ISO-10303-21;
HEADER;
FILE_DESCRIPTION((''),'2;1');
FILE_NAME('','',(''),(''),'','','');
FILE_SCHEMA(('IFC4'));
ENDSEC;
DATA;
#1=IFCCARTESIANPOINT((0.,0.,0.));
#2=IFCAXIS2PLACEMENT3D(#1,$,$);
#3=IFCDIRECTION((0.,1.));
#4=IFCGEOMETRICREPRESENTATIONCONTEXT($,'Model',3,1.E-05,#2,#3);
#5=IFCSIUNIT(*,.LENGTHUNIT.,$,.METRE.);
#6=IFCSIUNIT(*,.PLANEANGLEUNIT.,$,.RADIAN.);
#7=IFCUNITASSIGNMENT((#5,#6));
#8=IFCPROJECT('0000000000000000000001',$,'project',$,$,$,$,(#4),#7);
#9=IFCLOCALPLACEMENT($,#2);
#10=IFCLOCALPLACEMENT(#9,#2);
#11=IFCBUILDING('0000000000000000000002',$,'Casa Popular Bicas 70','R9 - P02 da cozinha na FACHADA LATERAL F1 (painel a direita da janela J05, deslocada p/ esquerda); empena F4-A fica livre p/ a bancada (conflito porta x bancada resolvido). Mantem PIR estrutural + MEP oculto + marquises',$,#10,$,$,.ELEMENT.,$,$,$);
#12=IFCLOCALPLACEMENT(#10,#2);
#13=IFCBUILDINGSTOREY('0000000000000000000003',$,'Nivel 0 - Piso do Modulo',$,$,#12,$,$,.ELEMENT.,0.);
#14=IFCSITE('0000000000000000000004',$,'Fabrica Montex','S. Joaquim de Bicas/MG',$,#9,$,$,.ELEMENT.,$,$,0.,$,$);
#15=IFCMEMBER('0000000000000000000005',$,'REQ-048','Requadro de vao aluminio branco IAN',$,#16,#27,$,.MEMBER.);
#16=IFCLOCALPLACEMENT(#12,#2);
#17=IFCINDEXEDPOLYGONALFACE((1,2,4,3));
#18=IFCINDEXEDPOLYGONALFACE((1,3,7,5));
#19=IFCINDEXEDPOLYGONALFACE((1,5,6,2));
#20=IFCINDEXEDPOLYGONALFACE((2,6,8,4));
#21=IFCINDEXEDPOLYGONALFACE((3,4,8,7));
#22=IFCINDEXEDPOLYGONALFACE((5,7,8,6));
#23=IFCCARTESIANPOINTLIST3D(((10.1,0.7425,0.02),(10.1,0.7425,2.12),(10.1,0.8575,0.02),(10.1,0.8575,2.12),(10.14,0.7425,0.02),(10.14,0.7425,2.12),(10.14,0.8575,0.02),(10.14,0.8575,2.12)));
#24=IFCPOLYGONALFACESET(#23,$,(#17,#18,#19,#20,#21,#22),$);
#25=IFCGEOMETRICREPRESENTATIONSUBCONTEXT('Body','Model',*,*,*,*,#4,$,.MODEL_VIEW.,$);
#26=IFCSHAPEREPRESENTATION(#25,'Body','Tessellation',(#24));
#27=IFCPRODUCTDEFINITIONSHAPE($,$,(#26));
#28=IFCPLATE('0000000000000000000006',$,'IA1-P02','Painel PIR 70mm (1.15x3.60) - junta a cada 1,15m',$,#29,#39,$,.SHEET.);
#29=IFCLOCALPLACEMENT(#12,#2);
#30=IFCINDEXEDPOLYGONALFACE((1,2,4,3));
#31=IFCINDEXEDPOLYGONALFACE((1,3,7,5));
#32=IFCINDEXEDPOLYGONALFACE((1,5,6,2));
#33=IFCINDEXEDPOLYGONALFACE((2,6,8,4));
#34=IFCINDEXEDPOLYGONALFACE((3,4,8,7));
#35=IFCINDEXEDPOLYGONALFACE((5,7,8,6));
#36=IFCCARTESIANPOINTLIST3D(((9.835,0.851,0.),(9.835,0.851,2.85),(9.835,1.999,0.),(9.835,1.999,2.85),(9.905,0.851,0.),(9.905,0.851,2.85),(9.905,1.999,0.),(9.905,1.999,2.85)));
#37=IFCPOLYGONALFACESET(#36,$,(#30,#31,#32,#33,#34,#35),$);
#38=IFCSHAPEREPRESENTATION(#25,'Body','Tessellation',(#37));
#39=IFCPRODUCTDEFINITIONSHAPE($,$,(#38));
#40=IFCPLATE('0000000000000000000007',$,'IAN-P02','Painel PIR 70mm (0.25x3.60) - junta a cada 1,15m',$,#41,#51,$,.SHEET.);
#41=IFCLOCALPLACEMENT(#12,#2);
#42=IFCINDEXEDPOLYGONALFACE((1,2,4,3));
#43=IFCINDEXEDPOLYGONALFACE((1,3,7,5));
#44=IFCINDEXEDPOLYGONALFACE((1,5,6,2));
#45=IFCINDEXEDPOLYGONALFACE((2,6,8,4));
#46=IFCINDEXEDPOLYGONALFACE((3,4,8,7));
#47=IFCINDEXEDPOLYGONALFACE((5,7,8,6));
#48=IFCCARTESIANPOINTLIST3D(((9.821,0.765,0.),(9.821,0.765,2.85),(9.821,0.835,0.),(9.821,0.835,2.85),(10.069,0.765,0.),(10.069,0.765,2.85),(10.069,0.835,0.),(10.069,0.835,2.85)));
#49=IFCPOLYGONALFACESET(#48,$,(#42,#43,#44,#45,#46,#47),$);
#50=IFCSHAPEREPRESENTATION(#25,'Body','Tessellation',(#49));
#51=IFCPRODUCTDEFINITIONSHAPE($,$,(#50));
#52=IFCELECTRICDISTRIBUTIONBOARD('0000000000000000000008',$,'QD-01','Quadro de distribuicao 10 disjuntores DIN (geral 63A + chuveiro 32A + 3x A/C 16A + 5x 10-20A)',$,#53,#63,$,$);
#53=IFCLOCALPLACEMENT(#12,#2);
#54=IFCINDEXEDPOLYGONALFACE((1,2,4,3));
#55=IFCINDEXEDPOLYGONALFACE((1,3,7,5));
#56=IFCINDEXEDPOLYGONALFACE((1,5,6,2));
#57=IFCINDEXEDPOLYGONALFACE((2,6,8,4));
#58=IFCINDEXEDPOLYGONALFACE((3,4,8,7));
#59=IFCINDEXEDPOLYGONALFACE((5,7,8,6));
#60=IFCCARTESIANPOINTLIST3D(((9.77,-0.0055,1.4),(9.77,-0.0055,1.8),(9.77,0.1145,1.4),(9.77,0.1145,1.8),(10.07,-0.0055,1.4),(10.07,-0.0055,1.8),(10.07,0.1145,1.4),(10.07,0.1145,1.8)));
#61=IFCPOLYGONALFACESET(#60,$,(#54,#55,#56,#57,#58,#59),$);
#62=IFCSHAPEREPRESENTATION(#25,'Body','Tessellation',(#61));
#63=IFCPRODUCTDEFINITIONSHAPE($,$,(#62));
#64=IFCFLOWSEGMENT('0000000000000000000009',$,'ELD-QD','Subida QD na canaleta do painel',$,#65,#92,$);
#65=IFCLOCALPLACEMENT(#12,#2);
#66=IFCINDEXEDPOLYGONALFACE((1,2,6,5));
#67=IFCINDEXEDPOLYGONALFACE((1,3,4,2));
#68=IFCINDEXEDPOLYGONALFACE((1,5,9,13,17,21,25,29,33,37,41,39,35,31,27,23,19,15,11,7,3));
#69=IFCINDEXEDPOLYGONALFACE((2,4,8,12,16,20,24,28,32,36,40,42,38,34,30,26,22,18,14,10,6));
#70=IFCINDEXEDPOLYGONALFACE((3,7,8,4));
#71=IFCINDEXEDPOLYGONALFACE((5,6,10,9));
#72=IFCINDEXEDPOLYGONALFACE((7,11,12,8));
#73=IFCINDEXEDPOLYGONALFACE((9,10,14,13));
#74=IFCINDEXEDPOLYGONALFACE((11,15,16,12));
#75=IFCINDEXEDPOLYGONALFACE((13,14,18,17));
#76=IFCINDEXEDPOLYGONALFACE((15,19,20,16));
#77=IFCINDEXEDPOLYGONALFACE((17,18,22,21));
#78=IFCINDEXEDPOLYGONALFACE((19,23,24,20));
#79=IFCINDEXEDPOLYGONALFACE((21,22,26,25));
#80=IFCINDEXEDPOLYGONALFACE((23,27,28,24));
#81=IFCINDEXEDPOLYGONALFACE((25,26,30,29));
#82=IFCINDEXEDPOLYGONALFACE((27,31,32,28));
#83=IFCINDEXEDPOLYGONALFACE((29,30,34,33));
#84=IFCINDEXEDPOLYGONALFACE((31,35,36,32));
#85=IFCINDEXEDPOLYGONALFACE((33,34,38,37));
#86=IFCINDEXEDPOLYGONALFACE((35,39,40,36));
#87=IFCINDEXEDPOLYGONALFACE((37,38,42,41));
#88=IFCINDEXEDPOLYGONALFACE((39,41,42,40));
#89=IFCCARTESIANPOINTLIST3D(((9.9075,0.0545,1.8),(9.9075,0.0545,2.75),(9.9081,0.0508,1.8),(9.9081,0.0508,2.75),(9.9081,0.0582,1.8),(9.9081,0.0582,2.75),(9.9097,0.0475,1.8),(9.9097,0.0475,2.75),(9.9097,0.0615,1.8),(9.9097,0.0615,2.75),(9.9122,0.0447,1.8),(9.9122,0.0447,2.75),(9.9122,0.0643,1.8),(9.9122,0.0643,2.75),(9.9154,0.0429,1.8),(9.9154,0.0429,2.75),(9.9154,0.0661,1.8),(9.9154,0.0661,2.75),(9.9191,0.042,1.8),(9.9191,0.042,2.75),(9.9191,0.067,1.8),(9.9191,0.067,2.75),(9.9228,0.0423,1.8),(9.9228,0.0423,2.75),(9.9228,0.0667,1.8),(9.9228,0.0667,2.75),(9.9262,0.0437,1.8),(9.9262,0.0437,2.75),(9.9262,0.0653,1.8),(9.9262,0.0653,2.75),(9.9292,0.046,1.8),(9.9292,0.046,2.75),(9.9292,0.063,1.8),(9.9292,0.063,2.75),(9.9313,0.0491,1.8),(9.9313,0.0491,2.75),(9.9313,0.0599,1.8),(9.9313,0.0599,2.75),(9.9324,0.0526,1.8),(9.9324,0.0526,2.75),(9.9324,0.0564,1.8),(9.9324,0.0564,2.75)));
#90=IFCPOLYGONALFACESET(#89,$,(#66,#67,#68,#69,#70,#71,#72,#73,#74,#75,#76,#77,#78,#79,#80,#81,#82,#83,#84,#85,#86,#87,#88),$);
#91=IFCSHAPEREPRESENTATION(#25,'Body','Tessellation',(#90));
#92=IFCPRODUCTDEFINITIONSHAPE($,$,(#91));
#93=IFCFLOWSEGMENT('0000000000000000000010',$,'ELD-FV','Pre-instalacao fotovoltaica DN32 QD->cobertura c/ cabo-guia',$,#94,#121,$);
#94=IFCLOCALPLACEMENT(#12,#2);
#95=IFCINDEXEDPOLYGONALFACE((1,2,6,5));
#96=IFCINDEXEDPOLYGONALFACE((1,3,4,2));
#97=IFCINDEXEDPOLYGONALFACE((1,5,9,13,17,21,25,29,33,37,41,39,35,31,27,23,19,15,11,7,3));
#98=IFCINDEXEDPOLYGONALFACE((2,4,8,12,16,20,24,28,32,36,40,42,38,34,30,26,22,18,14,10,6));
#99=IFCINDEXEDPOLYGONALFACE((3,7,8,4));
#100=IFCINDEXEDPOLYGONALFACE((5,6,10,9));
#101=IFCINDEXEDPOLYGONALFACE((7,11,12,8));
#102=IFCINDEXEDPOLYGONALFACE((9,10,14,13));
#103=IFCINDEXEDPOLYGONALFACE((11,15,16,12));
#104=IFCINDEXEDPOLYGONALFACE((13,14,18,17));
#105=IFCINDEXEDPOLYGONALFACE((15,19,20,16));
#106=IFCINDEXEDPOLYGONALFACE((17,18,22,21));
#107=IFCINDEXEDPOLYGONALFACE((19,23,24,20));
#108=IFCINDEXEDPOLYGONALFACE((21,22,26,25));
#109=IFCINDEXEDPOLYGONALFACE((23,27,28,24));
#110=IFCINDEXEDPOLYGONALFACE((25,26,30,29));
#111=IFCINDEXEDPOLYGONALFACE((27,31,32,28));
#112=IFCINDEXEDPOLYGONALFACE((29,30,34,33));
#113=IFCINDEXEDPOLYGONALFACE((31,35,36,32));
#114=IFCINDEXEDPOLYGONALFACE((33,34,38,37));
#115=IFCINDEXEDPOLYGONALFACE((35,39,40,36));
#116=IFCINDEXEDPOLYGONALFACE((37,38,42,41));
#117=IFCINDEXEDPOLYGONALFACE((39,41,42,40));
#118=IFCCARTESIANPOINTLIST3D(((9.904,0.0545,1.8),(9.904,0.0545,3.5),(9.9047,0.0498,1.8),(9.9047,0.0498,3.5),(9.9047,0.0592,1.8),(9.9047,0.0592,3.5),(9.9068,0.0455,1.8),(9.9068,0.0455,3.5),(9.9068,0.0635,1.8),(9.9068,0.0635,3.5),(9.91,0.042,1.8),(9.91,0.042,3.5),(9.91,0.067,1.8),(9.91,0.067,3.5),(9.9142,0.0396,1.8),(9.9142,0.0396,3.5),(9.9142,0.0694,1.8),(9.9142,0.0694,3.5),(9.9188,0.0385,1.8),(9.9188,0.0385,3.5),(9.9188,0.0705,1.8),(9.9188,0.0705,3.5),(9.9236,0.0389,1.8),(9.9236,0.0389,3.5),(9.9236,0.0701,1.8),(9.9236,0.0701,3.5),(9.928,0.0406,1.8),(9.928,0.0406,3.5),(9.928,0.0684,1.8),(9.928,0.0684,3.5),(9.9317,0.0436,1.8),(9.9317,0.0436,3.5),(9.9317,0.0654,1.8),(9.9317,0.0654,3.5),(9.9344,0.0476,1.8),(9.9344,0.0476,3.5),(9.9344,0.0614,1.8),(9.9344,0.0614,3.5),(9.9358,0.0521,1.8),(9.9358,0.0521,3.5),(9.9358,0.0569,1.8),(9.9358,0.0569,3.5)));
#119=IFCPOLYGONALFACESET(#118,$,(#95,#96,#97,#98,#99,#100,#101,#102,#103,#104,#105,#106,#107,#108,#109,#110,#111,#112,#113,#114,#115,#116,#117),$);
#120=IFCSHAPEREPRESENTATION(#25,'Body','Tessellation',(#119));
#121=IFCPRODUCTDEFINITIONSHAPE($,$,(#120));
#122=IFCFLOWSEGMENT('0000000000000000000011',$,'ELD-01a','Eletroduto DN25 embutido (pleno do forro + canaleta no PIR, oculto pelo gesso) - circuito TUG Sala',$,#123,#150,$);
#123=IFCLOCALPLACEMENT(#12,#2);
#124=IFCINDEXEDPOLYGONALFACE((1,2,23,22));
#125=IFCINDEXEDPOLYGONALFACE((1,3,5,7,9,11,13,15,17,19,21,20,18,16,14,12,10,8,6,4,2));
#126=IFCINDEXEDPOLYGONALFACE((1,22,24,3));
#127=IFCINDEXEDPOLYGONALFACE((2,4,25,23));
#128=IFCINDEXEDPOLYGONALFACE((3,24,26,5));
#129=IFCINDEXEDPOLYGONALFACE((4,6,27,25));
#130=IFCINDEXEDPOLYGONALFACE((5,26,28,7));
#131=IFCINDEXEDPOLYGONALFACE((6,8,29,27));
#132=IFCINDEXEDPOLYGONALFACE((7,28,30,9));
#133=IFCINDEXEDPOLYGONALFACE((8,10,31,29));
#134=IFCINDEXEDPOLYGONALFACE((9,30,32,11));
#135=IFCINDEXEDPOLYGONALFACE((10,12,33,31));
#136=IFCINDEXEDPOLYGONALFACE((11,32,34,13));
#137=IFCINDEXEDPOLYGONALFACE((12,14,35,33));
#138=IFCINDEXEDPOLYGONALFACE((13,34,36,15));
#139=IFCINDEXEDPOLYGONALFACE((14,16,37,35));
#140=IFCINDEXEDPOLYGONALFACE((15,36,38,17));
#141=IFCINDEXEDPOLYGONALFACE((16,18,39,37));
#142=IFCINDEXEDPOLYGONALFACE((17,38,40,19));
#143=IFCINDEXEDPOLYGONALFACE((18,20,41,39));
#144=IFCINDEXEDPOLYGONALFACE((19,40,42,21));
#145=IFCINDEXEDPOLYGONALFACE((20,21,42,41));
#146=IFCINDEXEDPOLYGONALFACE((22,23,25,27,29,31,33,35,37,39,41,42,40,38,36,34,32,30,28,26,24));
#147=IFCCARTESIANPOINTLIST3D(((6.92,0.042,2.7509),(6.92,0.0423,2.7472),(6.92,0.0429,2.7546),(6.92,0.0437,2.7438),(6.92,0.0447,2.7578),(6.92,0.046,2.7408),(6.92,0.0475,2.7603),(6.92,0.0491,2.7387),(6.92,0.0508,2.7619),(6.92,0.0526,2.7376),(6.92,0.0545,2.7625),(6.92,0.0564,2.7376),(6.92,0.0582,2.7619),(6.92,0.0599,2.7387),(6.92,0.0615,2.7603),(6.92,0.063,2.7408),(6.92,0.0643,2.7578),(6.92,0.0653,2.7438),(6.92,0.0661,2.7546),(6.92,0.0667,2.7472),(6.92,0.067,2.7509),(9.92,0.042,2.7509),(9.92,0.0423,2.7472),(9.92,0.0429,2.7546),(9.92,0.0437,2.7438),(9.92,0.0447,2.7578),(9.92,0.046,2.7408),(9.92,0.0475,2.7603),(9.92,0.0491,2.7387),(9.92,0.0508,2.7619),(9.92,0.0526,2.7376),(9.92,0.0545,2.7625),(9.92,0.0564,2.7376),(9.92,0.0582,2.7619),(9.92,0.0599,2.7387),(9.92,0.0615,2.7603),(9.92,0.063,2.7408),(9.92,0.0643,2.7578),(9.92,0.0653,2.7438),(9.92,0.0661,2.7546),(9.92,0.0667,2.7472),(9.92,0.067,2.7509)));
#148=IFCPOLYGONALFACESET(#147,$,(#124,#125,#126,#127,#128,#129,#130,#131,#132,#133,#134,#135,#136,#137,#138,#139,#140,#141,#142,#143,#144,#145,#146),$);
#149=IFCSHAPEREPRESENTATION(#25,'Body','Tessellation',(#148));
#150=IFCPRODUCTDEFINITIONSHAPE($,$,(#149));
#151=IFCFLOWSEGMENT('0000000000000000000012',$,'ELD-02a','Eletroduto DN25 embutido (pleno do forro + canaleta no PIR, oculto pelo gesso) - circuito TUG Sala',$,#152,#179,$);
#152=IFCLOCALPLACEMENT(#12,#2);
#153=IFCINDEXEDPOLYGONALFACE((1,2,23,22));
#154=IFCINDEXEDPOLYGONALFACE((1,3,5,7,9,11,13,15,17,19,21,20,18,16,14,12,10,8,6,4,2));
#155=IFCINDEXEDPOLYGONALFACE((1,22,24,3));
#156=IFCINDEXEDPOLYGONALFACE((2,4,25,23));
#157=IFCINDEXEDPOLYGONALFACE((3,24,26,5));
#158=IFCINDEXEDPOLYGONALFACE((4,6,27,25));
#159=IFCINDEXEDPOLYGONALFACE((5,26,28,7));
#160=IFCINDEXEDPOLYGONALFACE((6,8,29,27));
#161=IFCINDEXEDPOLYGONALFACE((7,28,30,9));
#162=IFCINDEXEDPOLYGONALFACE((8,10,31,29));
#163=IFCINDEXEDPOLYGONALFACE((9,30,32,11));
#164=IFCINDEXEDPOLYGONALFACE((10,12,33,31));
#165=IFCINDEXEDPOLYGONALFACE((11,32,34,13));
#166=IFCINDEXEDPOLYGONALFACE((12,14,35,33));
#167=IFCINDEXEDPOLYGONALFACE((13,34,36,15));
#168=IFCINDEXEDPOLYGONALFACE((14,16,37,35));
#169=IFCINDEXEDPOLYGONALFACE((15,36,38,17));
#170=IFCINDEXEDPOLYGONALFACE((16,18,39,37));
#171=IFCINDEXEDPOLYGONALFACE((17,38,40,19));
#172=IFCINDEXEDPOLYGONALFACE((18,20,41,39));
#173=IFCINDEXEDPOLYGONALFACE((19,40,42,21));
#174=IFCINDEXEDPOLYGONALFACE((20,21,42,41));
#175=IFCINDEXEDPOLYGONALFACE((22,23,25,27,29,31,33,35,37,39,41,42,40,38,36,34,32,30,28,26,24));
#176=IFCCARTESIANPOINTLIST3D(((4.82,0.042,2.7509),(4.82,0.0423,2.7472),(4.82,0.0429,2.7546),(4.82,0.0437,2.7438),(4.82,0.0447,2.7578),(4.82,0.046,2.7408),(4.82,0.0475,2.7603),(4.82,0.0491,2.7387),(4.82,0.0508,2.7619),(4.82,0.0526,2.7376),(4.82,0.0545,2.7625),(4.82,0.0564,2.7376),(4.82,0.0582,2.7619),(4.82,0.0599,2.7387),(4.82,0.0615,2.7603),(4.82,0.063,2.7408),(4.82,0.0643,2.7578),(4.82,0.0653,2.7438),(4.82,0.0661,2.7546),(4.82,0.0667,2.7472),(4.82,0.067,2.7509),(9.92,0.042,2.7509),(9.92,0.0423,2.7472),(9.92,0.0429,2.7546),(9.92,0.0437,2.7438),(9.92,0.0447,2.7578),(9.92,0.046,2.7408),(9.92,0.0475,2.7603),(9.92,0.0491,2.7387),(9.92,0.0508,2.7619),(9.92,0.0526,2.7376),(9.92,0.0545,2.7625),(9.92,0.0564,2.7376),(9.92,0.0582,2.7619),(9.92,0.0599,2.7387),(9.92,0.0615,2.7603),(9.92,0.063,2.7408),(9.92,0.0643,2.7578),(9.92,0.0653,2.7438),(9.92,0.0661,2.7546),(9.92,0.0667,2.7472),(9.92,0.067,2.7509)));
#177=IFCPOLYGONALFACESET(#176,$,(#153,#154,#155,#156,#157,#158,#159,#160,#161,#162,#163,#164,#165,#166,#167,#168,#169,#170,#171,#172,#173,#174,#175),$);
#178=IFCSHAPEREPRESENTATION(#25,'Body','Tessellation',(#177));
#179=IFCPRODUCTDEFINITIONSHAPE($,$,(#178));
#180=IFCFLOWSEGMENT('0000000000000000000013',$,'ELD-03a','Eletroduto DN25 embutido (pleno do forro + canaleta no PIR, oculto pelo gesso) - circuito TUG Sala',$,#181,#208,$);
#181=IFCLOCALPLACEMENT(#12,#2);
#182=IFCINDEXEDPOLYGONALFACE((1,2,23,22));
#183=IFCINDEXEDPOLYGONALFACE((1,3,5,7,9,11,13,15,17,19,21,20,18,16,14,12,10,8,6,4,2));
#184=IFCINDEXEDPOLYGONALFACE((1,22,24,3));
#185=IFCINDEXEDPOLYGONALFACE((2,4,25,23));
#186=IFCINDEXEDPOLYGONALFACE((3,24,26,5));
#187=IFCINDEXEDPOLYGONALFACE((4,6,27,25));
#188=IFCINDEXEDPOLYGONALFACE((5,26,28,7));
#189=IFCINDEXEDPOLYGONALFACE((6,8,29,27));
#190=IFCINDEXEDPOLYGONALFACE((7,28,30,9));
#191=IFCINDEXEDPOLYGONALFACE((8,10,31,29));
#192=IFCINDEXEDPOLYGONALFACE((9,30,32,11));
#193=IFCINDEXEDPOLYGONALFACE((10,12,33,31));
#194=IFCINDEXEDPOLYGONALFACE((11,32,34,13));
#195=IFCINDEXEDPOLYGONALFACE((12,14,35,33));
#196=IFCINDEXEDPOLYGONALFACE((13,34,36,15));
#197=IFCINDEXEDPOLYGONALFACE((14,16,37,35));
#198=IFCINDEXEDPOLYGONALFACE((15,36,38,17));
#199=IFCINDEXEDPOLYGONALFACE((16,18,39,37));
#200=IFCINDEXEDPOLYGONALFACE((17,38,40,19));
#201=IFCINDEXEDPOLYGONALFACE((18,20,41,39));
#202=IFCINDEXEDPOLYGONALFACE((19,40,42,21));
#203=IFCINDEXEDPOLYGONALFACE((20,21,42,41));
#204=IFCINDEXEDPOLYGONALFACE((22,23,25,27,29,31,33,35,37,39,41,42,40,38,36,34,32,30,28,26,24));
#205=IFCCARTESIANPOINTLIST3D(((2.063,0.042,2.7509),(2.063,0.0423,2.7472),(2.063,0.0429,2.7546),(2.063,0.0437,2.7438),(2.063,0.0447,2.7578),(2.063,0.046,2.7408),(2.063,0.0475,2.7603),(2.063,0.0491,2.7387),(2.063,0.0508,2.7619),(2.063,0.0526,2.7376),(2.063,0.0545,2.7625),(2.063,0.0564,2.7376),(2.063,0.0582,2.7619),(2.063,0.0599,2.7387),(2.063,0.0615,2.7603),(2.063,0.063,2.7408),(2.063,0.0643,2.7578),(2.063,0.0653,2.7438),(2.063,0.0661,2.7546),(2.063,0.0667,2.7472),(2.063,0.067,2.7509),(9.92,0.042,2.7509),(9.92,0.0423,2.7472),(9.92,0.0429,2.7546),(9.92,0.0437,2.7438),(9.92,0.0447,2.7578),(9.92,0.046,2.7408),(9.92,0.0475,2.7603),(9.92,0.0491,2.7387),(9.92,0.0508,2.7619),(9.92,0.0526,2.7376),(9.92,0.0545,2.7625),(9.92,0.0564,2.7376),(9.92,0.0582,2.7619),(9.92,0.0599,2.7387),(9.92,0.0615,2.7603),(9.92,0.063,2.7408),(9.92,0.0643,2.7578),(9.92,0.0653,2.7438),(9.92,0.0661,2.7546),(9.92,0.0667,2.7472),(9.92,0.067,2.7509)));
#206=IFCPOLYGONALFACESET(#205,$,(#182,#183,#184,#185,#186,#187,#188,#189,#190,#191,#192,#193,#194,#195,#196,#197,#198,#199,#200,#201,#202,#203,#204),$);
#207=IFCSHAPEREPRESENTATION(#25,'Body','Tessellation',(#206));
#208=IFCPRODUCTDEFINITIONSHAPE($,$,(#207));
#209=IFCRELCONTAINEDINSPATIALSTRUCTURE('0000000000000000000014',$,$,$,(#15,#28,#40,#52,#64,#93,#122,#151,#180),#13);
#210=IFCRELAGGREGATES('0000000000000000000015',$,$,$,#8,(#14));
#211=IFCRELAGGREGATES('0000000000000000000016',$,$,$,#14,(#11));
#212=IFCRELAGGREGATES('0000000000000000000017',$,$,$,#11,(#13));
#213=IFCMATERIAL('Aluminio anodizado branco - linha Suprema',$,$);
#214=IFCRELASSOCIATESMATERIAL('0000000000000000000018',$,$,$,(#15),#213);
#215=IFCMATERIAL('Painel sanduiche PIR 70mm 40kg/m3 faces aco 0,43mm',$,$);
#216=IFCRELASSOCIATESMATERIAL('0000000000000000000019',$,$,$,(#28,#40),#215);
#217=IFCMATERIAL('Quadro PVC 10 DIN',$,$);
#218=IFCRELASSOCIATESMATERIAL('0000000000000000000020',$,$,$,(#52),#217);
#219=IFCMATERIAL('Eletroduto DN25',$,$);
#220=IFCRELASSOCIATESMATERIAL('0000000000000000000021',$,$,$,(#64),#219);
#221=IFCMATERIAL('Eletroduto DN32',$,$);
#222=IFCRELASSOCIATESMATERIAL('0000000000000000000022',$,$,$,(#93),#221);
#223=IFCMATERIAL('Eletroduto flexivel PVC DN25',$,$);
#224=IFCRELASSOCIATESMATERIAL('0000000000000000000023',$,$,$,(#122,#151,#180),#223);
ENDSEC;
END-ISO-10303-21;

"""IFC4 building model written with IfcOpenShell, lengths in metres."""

from ifc_helpers import new_model, si_unit, direction, frame, frame_2d, origin, origin_2d, place, context, subcontext, project, spatial, rectangle, circle, extrude, material, element, save


model = new_model("IFC4")

# Units and contexts
model_context = context("Model", 3, precision=1e-05, world=origin(), true_north=direction((0.0, 1.0)))
body_context = subcontext(model_context, "Body", "Model", "MODEL_VIEW")
ifc_project = project(units=[si_unit("LENGTHUNIT", "METRE"), si_unit("PLANEANGLEUNIT", "RADIAN")], contexts=[model_context])

# Site, building, storey
site_placement = place(None, origin())
site = spatial("IfcSite", under=ifc_project, at=site_placement, Name="Fabrica Montex", Description="S. Joaquim de Bicas/MG", CompositionType="ELEMENT", RefElevation=0.0)
building_placement = place(site_placement, origin())
building = spatial("IfcBuilding", under=site, at=building_placement, Name="Casa Popular Bicas 70", Description="R9 - P02 da cozinha na FACHADA LATERAL F1 (painel a direita da janela J05, deslocada p/ esquerda); empena F4-A fica livre p/ a bancada (conflito porta x bancada resolvido). Mantem PIR estrutural + MEP oculto + marquises", CompositionType="ELEMENT")
storey_placement = place(building_placement, origin())
storey = spatial("IfcBuildingStorey", under=building, at=storey_placement, Name="Nivel 0 - Piso do Modulo", CompositionType="ELEMENT", Elevation=0.0)

# Member
ifc_material_1 = material(Name="Aluminio anodizado branco - linha Suprema")
member_placement = place(None, frame((10.12, 0.8, 0.02), z_axis=(0.0, 0.0, 1.0), x_axis=(-1.0, 0.0, 0.0)))
element("IfcMember", 1, at=member_placement, inside=storey, material=ifc_material_1, Name="REQ-048", Description="Requadro de vao aluminio branco IAN", PredefinedType="MEMBER", context=body_context, shape_type="SweptSolid", body=[
    extrude(rectangle(XDim=0.04, YDim=0.115, at=origin_2d()), origin(), (0.0, 0.0, 1.0), 2.1),
])

# Shared definitions
ifc_material_2 = material(Name="Painel sanduiche PIR 70mm 40kg/m3 faces aco 0,43mm")

# Plates
plate_1_placement = place(None, frame((9.87, 1.999, 0.0), z_axis=(0.0, 0.0, 1.0), x_axis=(0.0, -1.0, 0.0)))
element("IfcPlate", 2, at=plate_1_placement, inside=storey, material=ifc_material_2, Name="IA1-P02", Description="Painel PIR 70mm (1.15x3.60) - junta a cada 1,15m", PredefinedType="SHEET", context=body_context, shape_type="SweptSolid", body=[
    extrude(rectangle(XDim=1.148, YDim=0.07, at=frame_2d((0.574, 0.0))), origin(), (0.0, 0.0, 1.0), 2.85),
])
plate_2_placement = place(None, frame((10.069, 0.8, 0.0), z_axis=(0.0, 0.0, 1.0), x_axis=(-1.0, 0.0, 0.0)))
element("IfcPlate", 3, at=plate_2_placement, inside=storey, material=ifc_material_2, Name="IAN-P02", Description="Painel PIR 70mm (0.25x3.60) - junta a cada 1,15m", PredefinedType="SHEET", context=body_context, shape_type="SweptSolid", body=[
    extrude(rectangle(XDim=0.248, YDim=0.07, at=frame_2d((0.124, 0.0))), origin(), (0.0, 0.0, 1.0), 2.85),
])

# Electric distribution board
ifc_material_3 = material(Name="Quadro PVC 10 DIN")
electric_distribution_board_placement = place(None, frame((10.07, 0.1145, 1.4), z_axis=(0.0, 0.0, 1.0), x_axis=(-1.0, 0.0, 0.0)))
element("IfcElectricDistributionBoard", 4, at=electric_distribution_board_placement, inside=storey, material=ifc_material_3, Name="QD-01", Description="Quadro de distribuicao 10 disjuntores DIN (geral 63A + chuveiro 32A + 3x A/C 16A + 5x 10-20A)", context=body_context, shape_type="SweptSolid", body=[
    extrude(rectangle(XDim=0.3, YDim=0.12, at=frame_2d((0.15, 0.06))), origin(), (0.0, 0.0, 1.0), 0.4),
])

# Flow segments
ifc_material_4 = material(Name="Eletroduto DN25")
flow_segment_1_placement = place(None, frame((9.92, 0.0545, 1.8), z_axis=(0.0, 0.0, 1.0), x_axis=(-1.0, 0.0, 0.0)))
element("IfcFlowSegment", 5, at=flow_segment_1_placement, inside=storey, material=ifc_material_4, Name="ELD-QD", Description="Subida QD na canaleta do painel", context=body_context, shape_type="SweptSolid", body=[
    extrude(circle(Radius=0.0125, at=origin_2d()), origin(), (0.0, 0.0, 1.0), 0.95),
])
ifc_material_5 = material(Name="Eletroduto DN32")
flow_segment_2_placement = place(None, frame((9.92, 0.0545, 1.8), z_axis=(0.0, 0.0, 1.0), x_axis=(-1.0, 0.0, 0.0)))
element("IfcFlowSegment", 6, at=flow_segment_2_placement, inside=storey, material=ifc_material_5, Name="ELD-FV", Description="Pre-instalacao fotovoltaica DN32 QD->cobertura c/ cabo-guia", context=body_context, shape_type="SweptSolid", body=[
    extrude(circle(Radius=0.016, at=origin_2d()), origin(), (0.0, 0.0, 1.0), 1.7),
])
ifc_material_6 = material(Name="Eletroduto flexivel PVC DN25")
flow_segment_3_placement = place(None, frame((9.92, 0.0545, 2.75), z_axis=(-1.0, 0.0, 0.0), x_axis=(0.0, 0.0, 1.0)))
element("IfcFlowSegment", 7, at=flow_segment_3_placement, inside=storey, material=ifc_material_6, Name="ELD-01a", Description="Eletroduto DN25 embutido (pleno do forro + canaleta no PIR, oculto pelo gesso) - circuito TUG Sala", context=body_context, shape_type="SweptSolid", body=[
    extrude(circle(Radius=0.0125, at=origin_2d()), origin(), (0.0, 0.0, 1.0), 3.0),
])
flow_segment_4_placement = place(None, frame((9.92, 0.0545, 2.75), z_axis=(-1.0, 0.0, 0.0), x_axis=(0.0, 0.0, 1.0)))
element("IfcFlowSegment", 8, at=flow_segment_4_placement, inside=storey, material=ifc_material_6, Name="ELD-02a", Description="Eletroduto DN25 embutido (pleno do forro + canaleta no PIR, oculto pelo gesso) - circuito TUG Sala", context=body_context, shape_type="SweptSolid", body=[
    extrude(circle(Radius=0.0125, at=origin_2d()), origin(), (0.0, 0.0, 1.0), 5.1),
])
flow_segment_5_placement = place(None, frame((9.92, 0.0545, 2.75), z_axis=(-1.0, 0.0, 0.0), x_axis=(0.0, 0.0, 1.0)))
element("IfcFlowSegment", 9, at=flow_segment_5_placement, inside=storey, material=ifc_material_6, Name="ELD-03a", Description="Eletroduto DN25 embutido (pleno do forro + canaleta no PIR, oculto pelo gesso) - circuito TUG Sala", context=body_context, shape_type="SweptSolid", body=[
    extrude(circle(Radius=0.0125, at=origin_2d()), origin(), (0.0, 0.0, 1.0), 7.857),
])

save(model, "model.ifc")
